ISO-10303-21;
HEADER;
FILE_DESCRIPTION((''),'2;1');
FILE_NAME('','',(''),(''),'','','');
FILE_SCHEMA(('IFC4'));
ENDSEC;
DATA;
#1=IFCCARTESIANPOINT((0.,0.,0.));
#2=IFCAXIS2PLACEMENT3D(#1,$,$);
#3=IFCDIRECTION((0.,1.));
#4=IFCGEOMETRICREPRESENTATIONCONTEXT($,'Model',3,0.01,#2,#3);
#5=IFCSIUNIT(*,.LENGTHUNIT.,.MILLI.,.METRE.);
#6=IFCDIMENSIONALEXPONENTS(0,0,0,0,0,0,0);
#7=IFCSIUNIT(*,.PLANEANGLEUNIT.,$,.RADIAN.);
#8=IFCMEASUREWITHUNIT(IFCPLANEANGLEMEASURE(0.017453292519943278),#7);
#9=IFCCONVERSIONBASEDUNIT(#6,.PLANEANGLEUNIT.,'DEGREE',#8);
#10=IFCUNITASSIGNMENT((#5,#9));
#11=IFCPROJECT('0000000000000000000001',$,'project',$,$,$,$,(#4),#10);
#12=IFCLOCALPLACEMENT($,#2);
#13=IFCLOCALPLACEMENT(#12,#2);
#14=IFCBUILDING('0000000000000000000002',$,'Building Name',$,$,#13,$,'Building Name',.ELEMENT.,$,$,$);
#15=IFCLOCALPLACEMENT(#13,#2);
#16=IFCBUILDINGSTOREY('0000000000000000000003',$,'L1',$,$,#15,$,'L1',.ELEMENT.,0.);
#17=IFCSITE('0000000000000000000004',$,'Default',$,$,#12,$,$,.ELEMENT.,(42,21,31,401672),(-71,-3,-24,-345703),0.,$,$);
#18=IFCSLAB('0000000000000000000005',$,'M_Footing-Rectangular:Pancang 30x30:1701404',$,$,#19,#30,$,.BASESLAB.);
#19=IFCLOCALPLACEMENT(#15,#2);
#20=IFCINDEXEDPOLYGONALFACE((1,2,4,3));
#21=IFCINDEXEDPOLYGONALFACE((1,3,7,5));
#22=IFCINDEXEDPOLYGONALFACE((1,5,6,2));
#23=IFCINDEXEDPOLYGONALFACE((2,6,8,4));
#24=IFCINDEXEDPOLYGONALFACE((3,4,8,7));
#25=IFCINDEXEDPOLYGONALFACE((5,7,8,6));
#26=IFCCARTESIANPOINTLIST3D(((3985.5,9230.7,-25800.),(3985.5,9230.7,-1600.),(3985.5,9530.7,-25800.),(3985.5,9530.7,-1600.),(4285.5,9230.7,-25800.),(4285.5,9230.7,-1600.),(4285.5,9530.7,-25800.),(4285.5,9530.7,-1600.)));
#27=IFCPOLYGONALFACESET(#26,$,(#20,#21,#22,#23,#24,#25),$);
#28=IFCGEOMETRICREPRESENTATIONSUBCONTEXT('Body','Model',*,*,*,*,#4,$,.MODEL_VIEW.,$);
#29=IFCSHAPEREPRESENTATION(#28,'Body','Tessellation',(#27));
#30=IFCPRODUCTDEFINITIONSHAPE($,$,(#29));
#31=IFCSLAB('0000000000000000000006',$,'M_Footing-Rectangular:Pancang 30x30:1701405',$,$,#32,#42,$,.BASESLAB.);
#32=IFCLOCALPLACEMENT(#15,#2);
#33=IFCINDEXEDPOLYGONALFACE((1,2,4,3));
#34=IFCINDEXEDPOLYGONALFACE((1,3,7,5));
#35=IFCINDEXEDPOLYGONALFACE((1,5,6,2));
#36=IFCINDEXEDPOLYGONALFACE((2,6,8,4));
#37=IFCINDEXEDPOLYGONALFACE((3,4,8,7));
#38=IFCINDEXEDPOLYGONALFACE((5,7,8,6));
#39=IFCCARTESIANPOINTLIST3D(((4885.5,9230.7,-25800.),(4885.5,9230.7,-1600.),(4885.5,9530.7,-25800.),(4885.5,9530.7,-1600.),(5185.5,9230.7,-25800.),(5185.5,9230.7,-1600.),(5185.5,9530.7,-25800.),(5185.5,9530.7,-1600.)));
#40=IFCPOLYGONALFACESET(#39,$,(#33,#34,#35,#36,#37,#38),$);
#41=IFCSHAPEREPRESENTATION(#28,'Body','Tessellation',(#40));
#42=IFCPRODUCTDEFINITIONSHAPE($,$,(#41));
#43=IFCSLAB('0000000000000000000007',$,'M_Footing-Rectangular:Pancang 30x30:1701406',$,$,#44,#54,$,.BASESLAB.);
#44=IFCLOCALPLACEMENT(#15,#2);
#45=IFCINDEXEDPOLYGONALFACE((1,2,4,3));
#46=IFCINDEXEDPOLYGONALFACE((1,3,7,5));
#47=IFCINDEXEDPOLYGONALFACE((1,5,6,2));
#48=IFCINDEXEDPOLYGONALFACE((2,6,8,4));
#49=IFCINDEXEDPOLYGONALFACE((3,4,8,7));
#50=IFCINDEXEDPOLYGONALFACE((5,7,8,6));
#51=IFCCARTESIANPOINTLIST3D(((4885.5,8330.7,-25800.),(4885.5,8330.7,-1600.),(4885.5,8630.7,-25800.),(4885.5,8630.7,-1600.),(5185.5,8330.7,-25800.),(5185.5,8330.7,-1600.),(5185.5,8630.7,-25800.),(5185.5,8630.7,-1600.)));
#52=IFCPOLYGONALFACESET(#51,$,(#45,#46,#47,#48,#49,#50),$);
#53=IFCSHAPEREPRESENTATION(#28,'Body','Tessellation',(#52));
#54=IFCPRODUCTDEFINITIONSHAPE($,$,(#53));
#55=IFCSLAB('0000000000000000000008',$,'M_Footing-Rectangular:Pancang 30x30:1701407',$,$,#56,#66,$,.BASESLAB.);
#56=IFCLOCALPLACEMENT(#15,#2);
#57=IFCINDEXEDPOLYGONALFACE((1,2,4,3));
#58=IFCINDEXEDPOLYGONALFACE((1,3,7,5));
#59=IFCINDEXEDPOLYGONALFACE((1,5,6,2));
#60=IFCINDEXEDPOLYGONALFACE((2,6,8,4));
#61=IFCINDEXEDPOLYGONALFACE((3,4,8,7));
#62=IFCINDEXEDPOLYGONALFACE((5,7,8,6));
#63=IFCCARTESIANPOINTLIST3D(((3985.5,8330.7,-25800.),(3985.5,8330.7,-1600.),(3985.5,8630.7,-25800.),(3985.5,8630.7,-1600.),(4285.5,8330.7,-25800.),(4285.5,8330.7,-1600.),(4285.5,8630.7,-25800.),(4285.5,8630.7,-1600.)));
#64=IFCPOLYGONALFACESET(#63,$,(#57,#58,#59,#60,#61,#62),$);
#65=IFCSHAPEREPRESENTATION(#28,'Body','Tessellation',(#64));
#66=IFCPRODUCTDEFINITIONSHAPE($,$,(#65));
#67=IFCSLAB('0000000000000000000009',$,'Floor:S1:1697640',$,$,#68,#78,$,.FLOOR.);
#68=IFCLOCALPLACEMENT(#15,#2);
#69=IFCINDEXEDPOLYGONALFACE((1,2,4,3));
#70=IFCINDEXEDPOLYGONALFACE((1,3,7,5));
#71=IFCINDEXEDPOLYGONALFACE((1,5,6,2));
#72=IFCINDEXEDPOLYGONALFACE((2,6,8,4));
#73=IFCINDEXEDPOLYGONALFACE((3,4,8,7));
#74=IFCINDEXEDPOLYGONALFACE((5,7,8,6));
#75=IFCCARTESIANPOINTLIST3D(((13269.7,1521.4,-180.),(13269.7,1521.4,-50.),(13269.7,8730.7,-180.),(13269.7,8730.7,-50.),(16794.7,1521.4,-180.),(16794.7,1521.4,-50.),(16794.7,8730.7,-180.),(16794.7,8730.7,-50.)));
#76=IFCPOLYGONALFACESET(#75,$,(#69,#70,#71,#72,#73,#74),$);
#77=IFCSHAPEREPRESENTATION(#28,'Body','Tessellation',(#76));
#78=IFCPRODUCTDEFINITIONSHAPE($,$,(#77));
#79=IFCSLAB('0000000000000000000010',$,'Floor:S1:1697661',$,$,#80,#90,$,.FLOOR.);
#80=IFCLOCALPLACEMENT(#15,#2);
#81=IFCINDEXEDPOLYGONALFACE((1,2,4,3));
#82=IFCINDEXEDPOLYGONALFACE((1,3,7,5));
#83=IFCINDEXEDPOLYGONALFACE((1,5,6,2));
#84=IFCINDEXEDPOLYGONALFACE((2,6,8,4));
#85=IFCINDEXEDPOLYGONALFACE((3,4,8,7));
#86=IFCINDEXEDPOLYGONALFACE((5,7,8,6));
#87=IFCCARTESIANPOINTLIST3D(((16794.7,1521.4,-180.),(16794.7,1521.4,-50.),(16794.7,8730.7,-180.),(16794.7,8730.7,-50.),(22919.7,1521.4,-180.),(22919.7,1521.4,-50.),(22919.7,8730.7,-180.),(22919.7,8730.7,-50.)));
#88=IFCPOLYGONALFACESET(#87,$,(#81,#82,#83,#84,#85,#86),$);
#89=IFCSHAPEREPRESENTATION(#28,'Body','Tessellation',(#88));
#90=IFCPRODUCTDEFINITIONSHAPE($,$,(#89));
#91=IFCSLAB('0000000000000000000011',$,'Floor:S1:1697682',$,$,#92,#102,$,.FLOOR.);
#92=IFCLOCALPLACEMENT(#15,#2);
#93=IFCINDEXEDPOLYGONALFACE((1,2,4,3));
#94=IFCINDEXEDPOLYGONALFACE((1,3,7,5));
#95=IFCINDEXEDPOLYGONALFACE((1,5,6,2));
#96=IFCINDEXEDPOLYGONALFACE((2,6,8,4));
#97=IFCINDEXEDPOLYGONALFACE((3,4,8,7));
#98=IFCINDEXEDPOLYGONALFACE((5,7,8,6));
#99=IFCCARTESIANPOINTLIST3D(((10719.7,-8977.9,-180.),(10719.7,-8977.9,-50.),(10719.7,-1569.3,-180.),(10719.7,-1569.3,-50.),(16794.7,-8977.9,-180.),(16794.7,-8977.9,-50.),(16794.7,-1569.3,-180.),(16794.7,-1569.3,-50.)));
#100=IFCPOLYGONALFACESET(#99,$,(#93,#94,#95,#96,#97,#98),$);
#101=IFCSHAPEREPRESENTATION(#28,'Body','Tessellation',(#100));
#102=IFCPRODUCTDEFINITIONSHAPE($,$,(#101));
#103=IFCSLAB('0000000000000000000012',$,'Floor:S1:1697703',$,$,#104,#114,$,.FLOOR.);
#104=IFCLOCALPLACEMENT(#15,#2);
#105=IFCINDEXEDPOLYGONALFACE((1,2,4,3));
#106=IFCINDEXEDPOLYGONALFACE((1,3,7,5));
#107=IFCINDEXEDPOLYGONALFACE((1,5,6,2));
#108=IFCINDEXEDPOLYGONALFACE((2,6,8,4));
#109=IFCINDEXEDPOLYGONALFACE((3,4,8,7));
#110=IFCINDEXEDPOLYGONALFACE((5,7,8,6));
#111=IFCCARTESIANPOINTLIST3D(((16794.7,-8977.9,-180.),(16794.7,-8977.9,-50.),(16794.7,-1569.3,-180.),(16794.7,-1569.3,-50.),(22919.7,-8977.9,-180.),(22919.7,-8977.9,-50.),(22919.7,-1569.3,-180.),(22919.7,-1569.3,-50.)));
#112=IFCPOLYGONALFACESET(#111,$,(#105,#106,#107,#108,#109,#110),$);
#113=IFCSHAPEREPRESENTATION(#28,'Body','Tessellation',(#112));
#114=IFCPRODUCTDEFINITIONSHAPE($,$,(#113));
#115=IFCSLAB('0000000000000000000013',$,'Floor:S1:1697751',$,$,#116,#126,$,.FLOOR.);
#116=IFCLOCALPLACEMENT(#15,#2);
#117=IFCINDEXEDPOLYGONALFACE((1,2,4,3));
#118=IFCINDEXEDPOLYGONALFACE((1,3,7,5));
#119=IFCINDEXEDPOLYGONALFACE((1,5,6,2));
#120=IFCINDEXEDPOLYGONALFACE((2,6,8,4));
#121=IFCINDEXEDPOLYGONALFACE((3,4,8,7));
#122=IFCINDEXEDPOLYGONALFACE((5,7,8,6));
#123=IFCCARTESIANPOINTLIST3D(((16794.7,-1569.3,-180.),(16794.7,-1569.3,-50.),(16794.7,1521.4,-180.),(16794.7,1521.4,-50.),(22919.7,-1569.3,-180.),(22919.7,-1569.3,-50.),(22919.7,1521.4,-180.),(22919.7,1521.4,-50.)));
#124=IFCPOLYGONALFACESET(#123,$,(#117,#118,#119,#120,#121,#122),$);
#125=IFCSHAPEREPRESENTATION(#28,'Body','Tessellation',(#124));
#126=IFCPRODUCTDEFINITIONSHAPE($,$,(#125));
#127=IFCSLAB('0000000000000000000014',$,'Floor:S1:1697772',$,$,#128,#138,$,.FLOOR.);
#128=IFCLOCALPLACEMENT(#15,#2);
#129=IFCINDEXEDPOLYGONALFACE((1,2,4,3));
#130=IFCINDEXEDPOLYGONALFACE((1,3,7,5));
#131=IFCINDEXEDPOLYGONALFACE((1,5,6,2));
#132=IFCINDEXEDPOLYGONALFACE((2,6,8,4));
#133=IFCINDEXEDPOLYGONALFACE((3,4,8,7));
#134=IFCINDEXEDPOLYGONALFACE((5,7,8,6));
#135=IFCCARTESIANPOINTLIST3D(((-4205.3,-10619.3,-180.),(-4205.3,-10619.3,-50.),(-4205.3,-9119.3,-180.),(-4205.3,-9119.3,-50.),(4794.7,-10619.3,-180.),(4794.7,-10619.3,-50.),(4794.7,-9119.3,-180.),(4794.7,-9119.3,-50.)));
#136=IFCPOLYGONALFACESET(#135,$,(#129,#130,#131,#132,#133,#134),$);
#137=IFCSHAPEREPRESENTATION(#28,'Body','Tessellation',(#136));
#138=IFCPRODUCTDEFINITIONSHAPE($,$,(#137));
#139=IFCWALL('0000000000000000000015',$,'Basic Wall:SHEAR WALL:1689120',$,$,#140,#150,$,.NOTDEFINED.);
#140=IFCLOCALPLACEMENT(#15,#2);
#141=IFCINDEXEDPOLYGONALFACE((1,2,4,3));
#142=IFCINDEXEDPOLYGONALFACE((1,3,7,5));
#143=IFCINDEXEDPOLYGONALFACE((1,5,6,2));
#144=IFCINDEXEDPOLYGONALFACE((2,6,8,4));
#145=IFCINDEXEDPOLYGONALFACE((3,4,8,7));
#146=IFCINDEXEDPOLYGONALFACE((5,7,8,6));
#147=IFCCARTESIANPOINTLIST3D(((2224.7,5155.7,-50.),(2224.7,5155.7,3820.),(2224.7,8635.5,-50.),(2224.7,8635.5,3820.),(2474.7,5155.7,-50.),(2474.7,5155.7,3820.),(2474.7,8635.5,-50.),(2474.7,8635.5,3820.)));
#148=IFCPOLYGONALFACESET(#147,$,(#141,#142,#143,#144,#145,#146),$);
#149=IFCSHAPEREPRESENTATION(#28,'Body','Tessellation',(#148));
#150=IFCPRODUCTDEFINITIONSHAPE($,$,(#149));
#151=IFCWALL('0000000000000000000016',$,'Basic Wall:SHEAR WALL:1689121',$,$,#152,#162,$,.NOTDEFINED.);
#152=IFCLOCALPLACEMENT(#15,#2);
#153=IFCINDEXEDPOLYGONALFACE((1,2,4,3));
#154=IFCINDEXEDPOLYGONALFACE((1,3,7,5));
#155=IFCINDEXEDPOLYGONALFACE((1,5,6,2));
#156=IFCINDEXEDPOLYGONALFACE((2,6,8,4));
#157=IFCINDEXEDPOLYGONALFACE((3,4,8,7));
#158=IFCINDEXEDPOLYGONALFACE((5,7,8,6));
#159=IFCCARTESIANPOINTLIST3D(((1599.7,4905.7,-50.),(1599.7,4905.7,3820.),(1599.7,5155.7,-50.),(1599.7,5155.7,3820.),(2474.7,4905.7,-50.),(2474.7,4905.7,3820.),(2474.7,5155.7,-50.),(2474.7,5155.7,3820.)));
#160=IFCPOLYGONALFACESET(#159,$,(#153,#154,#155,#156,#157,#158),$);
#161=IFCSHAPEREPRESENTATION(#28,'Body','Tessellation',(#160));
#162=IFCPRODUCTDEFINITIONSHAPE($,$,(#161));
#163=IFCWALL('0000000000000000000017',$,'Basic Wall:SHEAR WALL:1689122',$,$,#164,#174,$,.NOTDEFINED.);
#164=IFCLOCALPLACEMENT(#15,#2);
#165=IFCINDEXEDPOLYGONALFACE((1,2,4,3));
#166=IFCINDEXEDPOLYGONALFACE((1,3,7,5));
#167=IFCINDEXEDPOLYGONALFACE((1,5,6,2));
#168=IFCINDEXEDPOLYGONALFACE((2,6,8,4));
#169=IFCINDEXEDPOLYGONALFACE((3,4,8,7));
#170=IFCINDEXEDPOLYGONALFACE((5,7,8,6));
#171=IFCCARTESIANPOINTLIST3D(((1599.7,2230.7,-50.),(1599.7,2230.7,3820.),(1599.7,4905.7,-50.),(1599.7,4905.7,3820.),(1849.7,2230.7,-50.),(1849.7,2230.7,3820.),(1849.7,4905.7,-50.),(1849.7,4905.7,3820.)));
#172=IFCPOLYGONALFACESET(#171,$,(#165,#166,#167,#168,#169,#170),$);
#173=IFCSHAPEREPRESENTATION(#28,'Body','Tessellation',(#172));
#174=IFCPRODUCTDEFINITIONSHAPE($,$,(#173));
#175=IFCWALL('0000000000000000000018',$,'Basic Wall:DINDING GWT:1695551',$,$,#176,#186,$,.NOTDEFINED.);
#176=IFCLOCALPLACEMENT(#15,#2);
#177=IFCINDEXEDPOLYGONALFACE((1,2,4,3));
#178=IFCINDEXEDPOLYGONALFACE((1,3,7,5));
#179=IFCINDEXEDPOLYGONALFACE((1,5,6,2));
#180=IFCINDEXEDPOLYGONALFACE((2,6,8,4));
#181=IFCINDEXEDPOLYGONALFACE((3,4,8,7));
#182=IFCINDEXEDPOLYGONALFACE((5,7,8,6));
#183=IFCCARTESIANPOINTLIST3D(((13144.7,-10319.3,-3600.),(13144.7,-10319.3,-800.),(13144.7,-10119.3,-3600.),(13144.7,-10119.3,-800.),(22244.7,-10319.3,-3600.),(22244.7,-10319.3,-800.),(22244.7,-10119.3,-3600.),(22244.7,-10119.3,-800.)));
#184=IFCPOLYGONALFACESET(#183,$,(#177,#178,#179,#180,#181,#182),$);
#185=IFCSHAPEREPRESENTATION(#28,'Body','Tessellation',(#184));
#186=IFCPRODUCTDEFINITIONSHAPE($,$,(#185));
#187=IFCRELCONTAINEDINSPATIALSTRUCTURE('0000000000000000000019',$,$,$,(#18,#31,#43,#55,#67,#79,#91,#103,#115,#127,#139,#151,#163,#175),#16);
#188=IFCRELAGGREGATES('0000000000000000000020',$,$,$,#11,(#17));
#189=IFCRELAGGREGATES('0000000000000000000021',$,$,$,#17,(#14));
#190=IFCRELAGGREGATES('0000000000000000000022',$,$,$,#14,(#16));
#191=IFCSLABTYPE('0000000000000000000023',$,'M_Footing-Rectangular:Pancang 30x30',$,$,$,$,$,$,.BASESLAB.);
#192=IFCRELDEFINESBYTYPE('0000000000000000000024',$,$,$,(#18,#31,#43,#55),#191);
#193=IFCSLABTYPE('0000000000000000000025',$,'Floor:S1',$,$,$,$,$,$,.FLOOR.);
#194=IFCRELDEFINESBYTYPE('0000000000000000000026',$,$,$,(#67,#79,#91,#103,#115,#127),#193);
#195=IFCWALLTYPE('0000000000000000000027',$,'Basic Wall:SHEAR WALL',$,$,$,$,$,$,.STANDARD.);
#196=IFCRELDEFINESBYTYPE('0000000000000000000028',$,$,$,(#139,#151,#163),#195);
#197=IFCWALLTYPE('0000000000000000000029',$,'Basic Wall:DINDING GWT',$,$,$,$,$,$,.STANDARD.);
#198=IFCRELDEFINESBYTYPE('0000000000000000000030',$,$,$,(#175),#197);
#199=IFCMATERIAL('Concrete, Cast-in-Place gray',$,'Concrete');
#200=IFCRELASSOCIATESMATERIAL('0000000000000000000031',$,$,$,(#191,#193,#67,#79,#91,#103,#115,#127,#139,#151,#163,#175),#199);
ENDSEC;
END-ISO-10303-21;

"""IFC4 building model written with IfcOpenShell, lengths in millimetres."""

from ifc_helpers import new_model, entity, si_unit, converted_unit, direction, frame, origin, place, context, subcontext, project, spatial, indexed_curve, outline, extrude, material, type_object, element, save


model = new_model("IFC4")

# Units and contexts
model_context = context("Model", 3, precision=0.01, world=origin(), true_north=direction((0.0, 1.0)))
body_context = subcontext(model_context, "Body", "Model", "MODEL_VIEW")
ifc_project = project(units=[si_unit("LENGTHUNIT", "METRE", prefix="MILLI"), converted_unit("PLANEANGLEUNIT", "DEGREE", entity("IfcPlaneAngleMeasure", 0.017453292519943278), si_unit("PLANEANGLEUNIT", "RADIAN"), dimensions=[0, 0, 0, 0, 0, 0, 0])], contexts=[model_context])

# Site, building, storey
site_placement = place(None, origin())
site = spatial("IfcSite", under=ifc_project, at=site_placement, Name="Default", CompositionType="ELEMENT", RefLatitude=(42, 21, 31, 401672), RefLongitude=(-71, -3, -24, -345703), RefElevation=0.0)
building_placement = place(site_placement, origin())
building = spatial("IfcBuilding", under=site, at=building_placement, Name="Building Name", LongName="Building Name", CompositionType="ELEMENT")
storey_placement = place(building_placement, origin())
storey = spatial("IfcBuildingStorey", under=building, at=storey_placement, Name="L1", LongName="L1", CompositionType="ELEMENT", Elevation=0.0)

# Slabs
ifc_material = material(Name="Concrete, Cast-in-Place gray", Category="Concrete")
slab_type_1 = type_object("IfcSlabType", Name="M_Footing-Rectangular:Pancang 30x30", PredefinedType="BASESLAB", material=ifc_material)
slab_1_placement = place(storey_placement, origin())
element("IfcSlab", 1, at=slab_1_placement, inside=storey, type_object=slab_type_1, Name="M_Footing-Rectangular:Pancang 30x30:1701404", PredefinedType="BASESLAB", context=body_context, shape_type="SweptSolid", body=[
    extrude(outline(indexed_curve([(-150.0, -150.0), (150.0, -150.0), (150.0, 150.0), (-150.0, 150.0), (-150.0, -150.0)], self_intersect=False)), frame((4135.5, 9380.7, -25800.0), z_axis=(0.0, 0.0, 1.0), x_axis=(-1.0, 0.0, 0.0)), (0.0, 0.0, 1.0), 24200.0),
])
slab_2_placement = place(storey_placement, origin())
element("IfcSlab", 2, at=slab_2_placement, inside=storey, type_object=slab_type_1, Name="M_Footing-Rectangular:Pancang 30x30:1701405", PredefinedType="BASESLAB", context=body_context, shape_type="SweptSolid", body=[
    extrude(outline(indexed_curve([(-150.0, -150.0), (150.0, -150.0), (150.0, 150.0), (-150.0, 150.0), (-150.0, -150.0)], self_intersect=False)), frame((5035.5, 9380.7, -25800.0), z_axis=(0.0, 0.0, 1.0), x_axis=(-1.0, 0.0, 0.0)), (0.0, 0.0, 1.0), 24200.0),
])
slab_3_placement = place(storey_placement, origin())
element("IfcSlab", 3, at=slab_3_placement, inside=storey, type_object=slab_type_1, Name="M_Footing-Rectangular:Pancang 30x30:1701406", PredefinedType="BASESLAB", context=body_context, shape_type="SweptSolid", body=[
    extrude(outline(indexed_curve([(-150.0, -150.0), (150.0, -150.0), (150.0, 150.0), (-150.0, 150.0), (-150.0, -150.0)], self_intersect=False)), frame((5035.5, 8480.7, -25800.0), z_axis=(0.0, 0.0, 1.0), x_axis=(-1.0, 0.0, 0.0)), (0.0, 0.0, 1.0), 24200.0),
])
slab_4_placement = place(storey_placement, origin())
element("IfcSlab", 4, at=slab_4_placement, inside=storey, type_object=slab_type_1, Name="M_Footing-Rectangular:Pancang 30x30:1701407", PredefinedType="BASESLAB", context=body_context, shape_type="SweptSolid", body=[
    extrude(outline(indexed_curve([(-150.0, -150.0), (150.0, -150.0), (150.0, 150.0), (-150.0, 150.0), (-150.0, -150.0)], self_intersect=False)), frame((4135.5, 8480.7, -25800.0), z_axis=(0.0, 0.0, 1.0), x_axis=(-1.0, 0.0, 0.0)), (0.0, 0.0, 1.0), 24200.0),
])
slab_type_2 = type_object("IfcSlabType", Name="Floor:S1", PredefinedType="FLOOR", material=ifc_material)
slab_5_placement = place(storey_placement, origin())
element("IfcSlab", 5, at=slab_5_placement, inside=storey, type_object=slab_type_2, material=ifc_material, Name="Floor:S1:1697640", PredefinedType="FLOOR", context=body_context, shape_type="SweptSolid", body=[
    extrude(outline(indexed_curve([(-3604.6, -1762.5), (3604.6, -1762.5), (3604.6, 1762.5), (-3604.6, 1762.5), (-3604.6, -1762.5)], self_intersect=False)), frame((15032.2, 5126.1, -50.0), z_axis=(0.0, 0.0, -1.0), x_axis=(0.0, 1.0, 0.0)), (0.0, 0.0, 1.0), 130.0),
])
slab_6_placement = place(storey_placement, origin())
element("IfcSlab", 6, at=slab_6_placement, inside=storey, type_object=slab_type_2, material=ifc_material, Name="Floor:S1:1697661", PredefinedType="FLOOR", context=body_context, shape_type="SweptSolid", body=[
    extrude(outline(indexed_curve([(-3604.6, -3062.5), (3604.6, -3062.5), (3604.6, 3062.5), (-3604.6, 3062.5), (-3604.6, -3062.5)], self_intersect=False)), frame((19857.2, 5126.1, -50.0), z_axis=(0.0, 0.0, -1.0), x_axis=(0.0, 1.0, 0.0)), (0.0, 0.0, 1.0), 130.0),
])
slab_7_placement = place(storey_placement, origin())
element("IfcSlab", 7, at=slab_7_placement, inside=storey, type_object=slab_type_2, material=ifc_material, Name="Floor:S1:1697682", PredefinedType="FLOOR", context=body_context, shape_type="SweptSolid", body=[
    extrude(outline(indexed_curve([(-3704.3, -3037.5), (3704.3, -3037.5), (3704.3, 3037.5), (-3704.3, 3037.5), (-3704.3, -3037.5)], self_intersect=False)), frame((13757.2, -5273.6, -50.0), z_axis=(0.0, 0.0, -1.0), x_axis=(0.0, 1.0, 0.0)), (0.0, 0.0, 1.0), 130.0),
])
slab_8_placement = place(storey_placement, origin())
element("IfcSlab", 8, at=slab_8_placement, inside=storey, type_object=slab_type_2, material=ifc_material, Name="Floor:S1:1697703", PredefinedType="FLOOR", context=body_context, shape_type="SweptSolid", body=[
    extrude(outline(indexed_curve([(-3704.3, -3062.5), (3704.3, -3062.5), (3704.3, 3062.5), (-3704.3, 3062.5), (-3704.3, -3062.5)], self_intersect=False)), frame((19857.2, -5273.6, -50.0), z_axis=(0.0, 0.0, -1.0), x_axis=(0.0, 1.0, 0.0)), (0.0, 0.0, 1.0), 130.0),
])
slab_9_placement = place(storey_placement, origin())
element("IfcSlab", 9, at=slab_9_placement, inside=storey, type_object=slab_type_2, material=ifc_material, Name="Floor:S1:1697751", PredefinedType="FLOOR", context=body_context, shape_type="SweptSolid", body=[
    extrude(outline(indexed_curve([(-1545.4, -3062.5), (1545.4, -3062.5), (1545.4, 3062.5), (-1545.4, 3062.5), (-1545.4, -3062.5)], self_intersect=False)), frame((19857.2, -23.9, -50.0), z_axis=(0.0, 0.0, -1.0), x_axis=(0.0, 1.0, 0.0)), (0.0, 0.0, 1.0), 130.0),
])
slab_10_placement = place(storey_placement, origin())
element("IfcSlab", 10, at=slab_10_placement, inside=storey, type_object=slab_type_2, material=ifc_material, Name="Floor:S1:1697772", PredefinedType="FLOOR", context=body_context, shape_type="SweptSolid", body=[
    extrude(outline(indexed_curve([(-750.0, -4500.0), (750.0, -4500.0), (750.0, 4500.0), (-750.0, 4500.0), (-750.0, -4500.0)], self_intersect=False)), frame((294.7, -9869.3, -50.0), z_axis=(0.0, 0.0, -1.0), x_axis=(0.0, 1.0, 0.0)), (0.0, 0.0, 1.0), 130.0),
])

# Walls
wall_type_1 = type_object("IfcWallType", Name="Basic Wall:SHEAR WALL", PredefinedType="STANDARD")
wall_1_placement = place(storey_placement, frame((2349.7, 8635.5, -50.0), z_axis=(0.0, 0.0, 1.0), x_axis=(0.0, -1.0, 0.0)))
element("IfcWall", 11, at=wall_1_placement, inside=storey, type_object=wall_type_1, material=ifc_material, Name="Basic Wall:SHEAR WALL:1689120", PredefinedType="NOTDEFINED", context=body_context, shape_type="SweptSolid", body=[
    extrude(outline(indexed_curve([(3479.9, 125.0), (0.0, 125.0), (0.0, -125.0), (3479.9, -125.0), (3479.9, 125.0)], self_intersect=False)), origin(), (0.0, 0.0, 1.0), 3870.0),
])
wall_2_placement = place(storey_placement, frame((2474.7, 5030.7, -50.0), z_axis=(0.0, 0.0, 1.0), x_axis=(-1.0, 0.0, 0.0)))
element("IfcWall", 12, at=wall_2_placement, inside=storey, type_object=wall_type_1, material=ifc_material, Name="Basic Wall:SHEAR WALL:1689121", PredefinedType="NOTDEFINED", context=body_context, shape_type="SweptSolid", body=[
    extrude(outline(indexed_curve([(875.0, 125.0), (0.0, 125.0), (0.0, -125.0), (875.0, -125.0), (875.0, 125.0)], self_intersect=False)), origin(), (0.0, 0.0, 1.0), 3870.0),
])
wall_3_placement = place(storey_placement, frame((1724.7, 4905.7, -50.0), z_axis=(0.0, 0.0, 1.0), x_axis=(0.0, -1.0, 0.0)))
element("IfcWall", 13, at=wall_3_placement, inside=storey, type_object=wall_type_1, material=ifc_material, Name="Basic Wall:SHEAR WALL:1689122", PredefinedType="NOTDEFINED", context=body_context, shape_type="SweptSolid", body=[
    extrude(outline(indexed_curve([(2675.0, 125.0), (0.0, 125.0), (0.0, -125.0), (2675.0, -125.0), (2675.0, 125.0)], self_intersect=False)), origin(), (0.0, 0.0, 1.0), 3870.0),
])
wall_type_2 = type_object("IfcWallType", Name="Basic Wall:DINDING GWT", PredefinedType="STANDARD")
wall_4_placement = place(storey_placement, frame((13144.7, -10219.3, -3600.0)))
element("IfcWall", 14, at=wall_4_placement, inside=storey, type_object=wall_type_2, material=ifc_material, Name="Basic Wall:DINDING GWT:1695551", PredefinedType="NOTDEFINED", context=body_context, shape_type="SweptSolid", body=[
    extrude(outline(indexed_curve([(9100.0, 100.0), (0.0, 100.0), (0.0, -100.0), (9100.0, -100.0), (9100.0, 100.0)], self_intersect=False)), origin(), (0.0, 0.0, 1.0), 2800.0),
])

save(model, "model.ifc")
